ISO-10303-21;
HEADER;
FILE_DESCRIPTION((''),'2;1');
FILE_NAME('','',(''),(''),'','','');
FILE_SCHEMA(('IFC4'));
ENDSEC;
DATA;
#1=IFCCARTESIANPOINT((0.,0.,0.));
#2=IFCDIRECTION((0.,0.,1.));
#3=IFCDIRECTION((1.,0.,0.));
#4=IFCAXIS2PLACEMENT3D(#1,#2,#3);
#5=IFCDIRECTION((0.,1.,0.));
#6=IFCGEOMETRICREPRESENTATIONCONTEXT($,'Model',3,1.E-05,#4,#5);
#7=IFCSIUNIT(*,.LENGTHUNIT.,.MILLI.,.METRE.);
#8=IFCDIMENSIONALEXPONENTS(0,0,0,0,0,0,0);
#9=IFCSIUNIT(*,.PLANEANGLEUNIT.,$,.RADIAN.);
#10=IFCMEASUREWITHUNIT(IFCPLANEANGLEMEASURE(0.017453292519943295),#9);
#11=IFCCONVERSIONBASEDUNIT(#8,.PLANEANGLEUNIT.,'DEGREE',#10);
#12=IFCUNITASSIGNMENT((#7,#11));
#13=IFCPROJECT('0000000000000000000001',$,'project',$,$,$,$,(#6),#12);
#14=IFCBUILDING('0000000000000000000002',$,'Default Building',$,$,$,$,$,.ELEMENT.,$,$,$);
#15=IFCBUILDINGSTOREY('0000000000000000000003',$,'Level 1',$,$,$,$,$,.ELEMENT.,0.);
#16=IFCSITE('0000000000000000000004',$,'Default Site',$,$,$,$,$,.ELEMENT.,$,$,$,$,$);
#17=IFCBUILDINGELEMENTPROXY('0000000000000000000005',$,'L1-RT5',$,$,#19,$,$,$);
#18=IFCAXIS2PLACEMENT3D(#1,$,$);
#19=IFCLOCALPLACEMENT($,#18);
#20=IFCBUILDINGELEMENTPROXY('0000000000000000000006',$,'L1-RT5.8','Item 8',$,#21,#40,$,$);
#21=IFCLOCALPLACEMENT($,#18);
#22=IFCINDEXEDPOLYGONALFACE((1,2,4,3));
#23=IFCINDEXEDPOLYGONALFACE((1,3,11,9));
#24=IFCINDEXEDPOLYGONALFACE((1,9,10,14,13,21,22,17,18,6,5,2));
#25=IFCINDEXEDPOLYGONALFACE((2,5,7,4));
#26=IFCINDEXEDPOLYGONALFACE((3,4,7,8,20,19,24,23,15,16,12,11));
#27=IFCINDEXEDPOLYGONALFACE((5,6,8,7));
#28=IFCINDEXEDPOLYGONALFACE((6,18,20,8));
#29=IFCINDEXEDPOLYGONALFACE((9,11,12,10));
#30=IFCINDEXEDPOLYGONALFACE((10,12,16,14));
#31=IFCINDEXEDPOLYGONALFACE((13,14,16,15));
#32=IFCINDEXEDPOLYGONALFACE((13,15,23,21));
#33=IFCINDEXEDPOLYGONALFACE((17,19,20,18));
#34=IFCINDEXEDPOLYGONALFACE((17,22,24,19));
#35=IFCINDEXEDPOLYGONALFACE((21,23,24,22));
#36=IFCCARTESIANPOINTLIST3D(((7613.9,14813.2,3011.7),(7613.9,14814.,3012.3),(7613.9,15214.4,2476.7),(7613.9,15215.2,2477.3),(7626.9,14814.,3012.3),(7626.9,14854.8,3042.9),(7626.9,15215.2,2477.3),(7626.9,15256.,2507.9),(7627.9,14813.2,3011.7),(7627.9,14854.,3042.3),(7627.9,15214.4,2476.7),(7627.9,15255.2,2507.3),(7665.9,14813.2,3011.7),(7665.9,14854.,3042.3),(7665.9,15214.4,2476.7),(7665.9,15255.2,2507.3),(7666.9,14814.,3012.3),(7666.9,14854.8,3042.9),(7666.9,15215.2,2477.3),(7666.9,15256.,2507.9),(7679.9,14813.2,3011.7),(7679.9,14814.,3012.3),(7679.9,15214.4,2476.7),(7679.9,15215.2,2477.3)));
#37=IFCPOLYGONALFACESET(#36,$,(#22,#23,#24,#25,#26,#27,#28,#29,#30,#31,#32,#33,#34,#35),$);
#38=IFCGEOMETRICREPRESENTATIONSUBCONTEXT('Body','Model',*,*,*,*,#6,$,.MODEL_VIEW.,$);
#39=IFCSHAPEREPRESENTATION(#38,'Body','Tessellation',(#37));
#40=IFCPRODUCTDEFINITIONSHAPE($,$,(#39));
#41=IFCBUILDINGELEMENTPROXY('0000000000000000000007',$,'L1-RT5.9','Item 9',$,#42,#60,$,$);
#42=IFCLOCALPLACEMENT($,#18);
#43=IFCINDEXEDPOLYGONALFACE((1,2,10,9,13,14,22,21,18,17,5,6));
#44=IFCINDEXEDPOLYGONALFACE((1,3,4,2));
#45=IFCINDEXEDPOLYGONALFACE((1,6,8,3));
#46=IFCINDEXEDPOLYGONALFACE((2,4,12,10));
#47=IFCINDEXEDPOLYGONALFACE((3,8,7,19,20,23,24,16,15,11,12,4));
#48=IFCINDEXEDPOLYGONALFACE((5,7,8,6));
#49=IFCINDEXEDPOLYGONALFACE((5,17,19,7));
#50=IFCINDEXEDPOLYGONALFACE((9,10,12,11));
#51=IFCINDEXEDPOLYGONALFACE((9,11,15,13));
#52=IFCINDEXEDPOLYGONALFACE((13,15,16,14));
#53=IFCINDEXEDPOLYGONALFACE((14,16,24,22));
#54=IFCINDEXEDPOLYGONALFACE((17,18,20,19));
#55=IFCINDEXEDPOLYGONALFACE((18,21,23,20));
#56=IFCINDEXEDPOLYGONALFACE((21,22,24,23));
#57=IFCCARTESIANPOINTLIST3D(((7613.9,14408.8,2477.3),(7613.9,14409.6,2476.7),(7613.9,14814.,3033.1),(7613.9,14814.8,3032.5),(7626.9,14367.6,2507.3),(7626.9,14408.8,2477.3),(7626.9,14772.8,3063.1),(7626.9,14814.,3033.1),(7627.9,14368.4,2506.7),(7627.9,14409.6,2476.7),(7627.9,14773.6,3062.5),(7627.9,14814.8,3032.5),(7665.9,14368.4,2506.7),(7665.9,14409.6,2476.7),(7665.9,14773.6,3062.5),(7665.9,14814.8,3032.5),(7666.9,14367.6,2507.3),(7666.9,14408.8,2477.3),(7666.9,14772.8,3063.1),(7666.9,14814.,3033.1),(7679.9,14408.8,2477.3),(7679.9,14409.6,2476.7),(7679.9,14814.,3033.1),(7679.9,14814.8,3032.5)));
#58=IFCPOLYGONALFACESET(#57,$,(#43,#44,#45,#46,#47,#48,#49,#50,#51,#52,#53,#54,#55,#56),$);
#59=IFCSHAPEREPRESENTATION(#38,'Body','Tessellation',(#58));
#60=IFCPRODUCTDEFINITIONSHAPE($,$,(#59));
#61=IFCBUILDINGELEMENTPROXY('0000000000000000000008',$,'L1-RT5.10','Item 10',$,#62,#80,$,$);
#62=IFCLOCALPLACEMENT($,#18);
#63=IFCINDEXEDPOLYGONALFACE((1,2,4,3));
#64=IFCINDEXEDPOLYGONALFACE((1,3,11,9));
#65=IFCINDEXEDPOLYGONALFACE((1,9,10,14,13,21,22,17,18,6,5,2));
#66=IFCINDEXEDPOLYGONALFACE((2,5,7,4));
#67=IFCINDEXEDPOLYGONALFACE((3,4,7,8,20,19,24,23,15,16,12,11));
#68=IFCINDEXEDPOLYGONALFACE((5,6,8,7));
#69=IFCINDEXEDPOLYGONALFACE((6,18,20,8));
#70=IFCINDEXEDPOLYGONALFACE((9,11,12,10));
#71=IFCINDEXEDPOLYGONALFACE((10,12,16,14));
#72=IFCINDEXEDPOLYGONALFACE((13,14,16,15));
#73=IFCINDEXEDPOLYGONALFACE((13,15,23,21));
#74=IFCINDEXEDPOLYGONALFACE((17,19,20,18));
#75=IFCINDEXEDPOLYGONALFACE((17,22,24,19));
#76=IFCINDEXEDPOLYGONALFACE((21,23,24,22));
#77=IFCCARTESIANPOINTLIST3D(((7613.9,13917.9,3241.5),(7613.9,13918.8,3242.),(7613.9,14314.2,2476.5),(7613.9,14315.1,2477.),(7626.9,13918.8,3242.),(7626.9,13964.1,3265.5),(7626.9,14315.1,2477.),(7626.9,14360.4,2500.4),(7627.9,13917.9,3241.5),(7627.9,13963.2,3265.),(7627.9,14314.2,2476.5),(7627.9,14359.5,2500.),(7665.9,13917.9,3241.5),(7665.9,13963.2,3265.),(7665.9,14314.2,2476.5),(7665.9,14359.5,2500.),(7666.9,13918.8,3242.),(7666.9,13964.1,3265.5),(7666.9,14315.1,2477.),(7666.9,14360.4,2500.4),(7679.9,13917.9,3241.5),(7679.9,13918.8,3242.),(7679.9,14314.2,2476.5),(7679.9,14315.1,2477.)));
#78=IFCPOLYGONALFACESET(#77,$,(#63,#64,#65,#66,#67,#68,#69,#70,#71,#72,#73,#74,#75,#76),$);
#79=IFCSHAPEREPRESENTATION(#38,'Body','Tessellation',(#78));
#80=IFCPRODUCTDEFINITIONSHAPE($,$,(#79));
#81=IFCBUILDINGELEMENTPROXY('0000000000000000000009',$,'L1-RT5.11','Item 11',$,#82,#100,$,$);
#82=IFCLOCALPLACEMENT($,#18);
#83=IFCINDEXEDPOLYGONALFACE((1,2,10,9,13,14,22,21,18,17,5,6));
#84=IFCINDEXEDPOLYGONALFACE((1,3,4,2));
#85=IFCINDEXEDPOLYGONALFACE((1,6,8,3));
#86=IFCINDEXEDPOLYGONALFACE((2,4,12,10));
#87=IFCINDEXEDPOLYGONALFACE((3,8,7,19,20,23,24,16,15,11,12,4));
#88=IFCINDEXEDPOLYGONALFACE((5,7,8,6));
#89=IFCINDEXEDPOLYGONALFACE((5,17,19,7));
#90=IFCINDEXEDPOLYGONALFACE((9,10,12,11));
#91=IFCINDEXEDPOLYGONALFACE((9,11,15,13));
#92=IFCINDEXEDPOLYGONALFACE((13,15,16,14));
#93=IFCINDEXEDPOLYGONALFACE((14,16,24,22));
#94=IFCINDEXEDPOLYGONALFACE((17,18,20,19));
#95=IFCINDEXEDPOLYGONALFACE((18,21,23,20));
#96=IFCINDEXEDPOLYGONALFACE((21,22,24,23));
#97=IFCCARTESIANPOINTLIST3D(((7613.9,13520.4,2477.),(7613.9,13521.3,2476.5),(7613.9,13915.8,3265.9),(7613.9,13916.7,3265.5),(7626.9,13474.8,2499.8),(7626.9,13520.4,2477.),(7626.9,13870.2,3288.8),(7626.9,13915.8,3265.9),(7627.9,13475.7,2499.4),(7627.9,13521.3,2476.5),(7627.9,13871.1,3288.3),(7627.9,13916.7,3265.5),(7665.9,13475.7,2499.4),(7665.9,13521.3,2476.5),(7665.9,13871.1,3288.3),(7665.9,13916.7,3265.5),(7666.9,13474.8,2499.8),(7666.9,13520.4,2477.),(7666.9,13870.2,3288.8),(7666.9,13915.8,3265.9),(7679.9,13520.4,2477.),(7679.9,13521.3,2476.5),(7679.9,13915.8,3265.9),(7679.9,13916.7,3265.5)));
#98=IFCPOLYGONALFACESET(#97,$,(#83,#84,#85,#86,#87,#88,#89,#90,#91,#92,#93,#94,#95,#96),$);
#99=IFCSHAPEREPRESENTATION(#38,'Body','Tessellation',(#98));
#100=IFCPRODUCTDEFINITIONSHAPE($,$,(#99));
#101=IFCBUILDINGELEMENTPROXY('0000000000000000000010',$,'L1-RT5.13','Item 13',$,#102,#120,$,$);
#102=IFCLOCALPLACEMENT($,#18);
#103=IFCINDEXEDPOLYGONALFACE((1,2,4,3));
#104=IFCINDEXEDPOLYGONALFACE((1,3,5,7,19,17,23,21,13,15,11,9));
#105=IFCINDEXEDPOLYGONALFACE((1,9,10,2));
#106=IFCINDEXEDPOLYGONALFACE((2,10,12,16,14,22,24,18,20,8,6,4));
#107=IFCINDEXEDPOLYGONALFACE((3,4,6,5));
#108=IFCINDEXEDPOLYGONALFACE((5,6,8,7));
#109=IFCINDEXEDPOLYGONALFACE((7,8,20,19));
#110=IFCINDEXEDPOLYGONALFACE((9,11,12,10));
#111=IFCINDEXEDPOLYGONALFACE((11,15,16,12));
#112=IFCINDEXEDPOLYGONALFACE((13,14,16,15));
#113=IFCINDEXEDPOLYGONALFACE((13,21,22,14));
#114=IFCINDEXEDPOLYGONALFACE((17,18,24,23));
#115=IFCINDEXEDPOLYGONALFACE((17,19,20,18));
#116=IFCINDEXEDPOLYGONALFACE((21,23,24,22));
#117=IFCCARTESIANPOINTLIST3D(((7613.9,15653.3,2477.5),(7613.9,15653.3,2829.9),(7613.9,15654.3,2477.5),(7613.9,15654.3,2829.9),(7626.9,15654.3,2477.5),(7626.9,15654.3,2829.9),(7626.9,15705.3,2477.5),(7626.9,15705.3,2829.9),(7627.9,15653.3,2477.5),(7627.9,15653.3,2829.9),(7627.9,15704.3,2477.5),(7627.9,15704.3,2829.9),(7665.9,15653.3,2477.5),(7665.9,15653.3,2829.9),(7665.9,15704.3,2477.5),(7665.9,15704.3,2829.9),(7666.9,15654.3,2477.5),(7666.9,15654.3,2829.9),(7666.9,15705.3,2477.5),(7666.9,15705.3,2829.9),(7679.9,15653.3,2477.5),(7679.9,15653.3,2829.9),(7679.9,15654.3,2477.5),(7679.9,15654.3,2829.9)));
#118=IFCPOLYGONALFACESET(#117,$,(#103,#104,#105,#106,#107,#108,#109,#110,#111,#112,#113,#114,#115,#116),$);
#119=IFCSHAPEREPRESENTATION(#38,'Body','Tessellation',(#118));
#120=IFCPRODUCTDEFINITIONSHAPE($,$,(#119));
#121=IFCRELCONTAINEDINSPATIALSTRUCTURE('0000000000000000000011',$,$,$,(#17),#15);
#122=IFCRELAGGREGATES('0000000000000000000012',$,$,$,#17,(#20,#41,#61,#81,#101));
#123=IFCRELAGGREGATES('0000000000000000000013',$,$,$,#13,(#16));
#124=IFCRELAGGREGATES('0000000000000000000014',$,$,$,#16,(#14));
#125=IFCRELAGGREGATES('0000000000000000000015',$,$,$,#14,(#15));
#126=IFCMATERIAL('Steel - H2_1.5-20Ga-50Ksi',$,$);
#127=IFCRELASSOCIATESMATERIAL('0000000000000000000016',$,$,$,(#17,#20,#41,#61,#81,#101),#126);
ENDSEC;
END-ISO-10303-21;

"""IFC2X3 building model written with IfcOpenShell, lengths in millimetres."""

from ifc_helpers import new_model, entity, si_unit, converted_unit, direction, frame, origin, origin_with_axes, place, context, subcontext, project, spatial, polyline, outline, extrude, material, element, aggregate, save


model = new_model("IFC2X3")

# Units and contexts
model_context = context("Model", 3, precision=1e-05, world=origin_with_axes(), true_north=direction((0.0, 1.0, 0.0)))
body_context = subcontext(model_context, "Body", "Model", "MODEL_VIEW")
ifc_project = project(units=[si_unit("LENGTHUNIT", "METRE", prefix="MILLI"), converted_unit("PLANEANGLEUNIT", "DEGREE", entity("IfcPlaneAngleMeasure", 0.017453292519943295), si_unit("PLANEANGLEUNIT", "RADIAN"), dimensions=[0, 0, 0, 0, 0, 0, 0])], contexts=[model_context])

# Site, building, storey
site = spatial("IfcSite", under=ifc_project, Name="Default Site", CompositionType="ELEMENT")
building = spatial("IfcBuilding", under=site, Name="Default Building", CompositionType="ELEMENT")
storey = spatial("IfcBuildingStorey", under=building, Name="Level 1", CompositionType="ELEMENT", Elevation=0.0)

# Building element proxies
ifc_material = material(Name="Steel - H2_1.5-20Ga-50Ksi")
proxy_1 = element("IfcBuildingElementProxy", 1, inside=storey, material=ifc_material, Name="L1-RT5")
proxy_2_placement = place(None, frame((7613.9, 15214.4, 2476.7), z_axis=(0.0, -0.6, 0.8), x_axis=(40.0, 0.0, 0.0)))
proxy_2 = element("IfcBuildingElementProxy", 2, at=proxy_2_placement, material=ifc_material, Name="L1-RT5.8", Description="Item 8", context=body_context, shape_type="SweptSolid", body=[
    extrude(outline(polyline([(0.0, 0.0), (14.0, 0.0), (14.0, 51.0), (52.0, 51.0), (52.0, 0.0), (66.0, 0.0), (66.0, 1.0), (53.0, 1.0), (53.0, 52.0), (13.0, 52.0), (13.0, 1.0), (0.0, 1.0), (0.0, 0.0)])), origin(), (0.0, 0.0, 1.0), 668.7),
])
proxy_3_placement = place(None, frame((7613.9, 14814.8, 3032.5), z_axis=(0.0, -0.589, -0.808), x_axis=(40.0, 0.0, 0.0)))
proxy_3 = element("IfcBuildingElementProxy", 3, at=proxy_3_placement, material=ifc_material, Name="L1-RT5.9", Description="Item 9", context=body_context, shape_type="SweptSolid", body=[
    extrude(outline(polyline([(0.0, 0.0), (14.0, 0.0), (14.0, 51.0), (52.0, 51.0), (52.0, 0.0), (66.0, 0.0), (66.0, 1.0), (53.0, 1.0), (53.0, 52.0), (13.0, 52.0), (13.0, 1.0), (0.0, 1.0), (0.0, 0.0)])), origin(), (0.0, 0.0, 1.0), 687.8),
])
proxy_4_placement = place(None, frame((7613.9, 14314.2, 2476.5), z_axis=(0.0, -0.46, 0.888), x_axis=(40.0, 0.0, 0.0)))
proxy_4 = element("IfcBuildingElementProxy", 4, at=proxy_4_placement, material=ifc_material, Name="L1-RT5.10", Description="Item 10", context=body_context, shape_type="SweptSolid", body=[
    extrude(outline(polyline([(0.0, 0.0), (14.0, 0.0), (14.0, 51.0), (52.0, 51.0), (52.0, 0.0), (66.0, 0.0), (66.0, 1.0), (53.0, 1.0), (53.0, 52.0), (13.0, 52.0), (13.0, 1.0), (0.0, 1.0), (0.0, 0.0)])), origin(), (0.0, 0.0, 1.0), 861.6),
])
proxy_5_placement = place(None, frame((7613.9, 13916.7, 3265.5), z_axis=(0.0, -0.448, -0.894), x_axis=(40.0, 0.0, 0.0)))
proxy_5 = element("IfcBuildingElementProxy", 5, at=proxy_5_placement, material=ifc_material, Name="L1-RT5.11", Description="Item 11", context=body_context, shape_type="SweptSolid", body=[
    extrude(outline(polyline([(0.0, 0.0), (14.0, 0.0), (14.0, 51.0), (52.0, 51.0), (52.0, 0.0), (66.0, 0.0), (66.0, 1.0), (53.0, 1.0), (53.0, 52.0), (13.0, 52.0), (13.0, 1.0), (0.0, 1.0), (0.0, 0.0)])), origin(), (0.0, 0.0, 1.0), 882.5),
])
proxy_6_placement = place(None, frame((7613.9, 15653.3, 2477.5), z_axis=(0.0, 0.0, 1.0), x_axis=(40.0, 0.0, 0.0)))
proxy_6 = element("IfcBuildingElementProxy", 6, at=proxy_6_placement, material=ifc_material, Name="L1-RT5.13", Description="Item 13", context=body_context, shape_type="SweptSolid", body=[
    extrude(outline(polyline([(0.0, 0.0), (14.0, 0.0), (14.0, 51.0), (52.0, 51.0), (52.0, 0.0), (66.0, 0.0), (66.0, 1.0), (53.0, 1.0), (53.0, 52.0), (13.0, 52.0), (13.0, 1.0), (0.0, 1.0), (0.0, 0.0)])), origin(), (0.0, 0.0, 1.0), 352.4),
])
aggregate(proxy_1, [proxy_2, proxy_3, proxy_4, proxy_5, proxy_6])

save(model, "model.ifc")
